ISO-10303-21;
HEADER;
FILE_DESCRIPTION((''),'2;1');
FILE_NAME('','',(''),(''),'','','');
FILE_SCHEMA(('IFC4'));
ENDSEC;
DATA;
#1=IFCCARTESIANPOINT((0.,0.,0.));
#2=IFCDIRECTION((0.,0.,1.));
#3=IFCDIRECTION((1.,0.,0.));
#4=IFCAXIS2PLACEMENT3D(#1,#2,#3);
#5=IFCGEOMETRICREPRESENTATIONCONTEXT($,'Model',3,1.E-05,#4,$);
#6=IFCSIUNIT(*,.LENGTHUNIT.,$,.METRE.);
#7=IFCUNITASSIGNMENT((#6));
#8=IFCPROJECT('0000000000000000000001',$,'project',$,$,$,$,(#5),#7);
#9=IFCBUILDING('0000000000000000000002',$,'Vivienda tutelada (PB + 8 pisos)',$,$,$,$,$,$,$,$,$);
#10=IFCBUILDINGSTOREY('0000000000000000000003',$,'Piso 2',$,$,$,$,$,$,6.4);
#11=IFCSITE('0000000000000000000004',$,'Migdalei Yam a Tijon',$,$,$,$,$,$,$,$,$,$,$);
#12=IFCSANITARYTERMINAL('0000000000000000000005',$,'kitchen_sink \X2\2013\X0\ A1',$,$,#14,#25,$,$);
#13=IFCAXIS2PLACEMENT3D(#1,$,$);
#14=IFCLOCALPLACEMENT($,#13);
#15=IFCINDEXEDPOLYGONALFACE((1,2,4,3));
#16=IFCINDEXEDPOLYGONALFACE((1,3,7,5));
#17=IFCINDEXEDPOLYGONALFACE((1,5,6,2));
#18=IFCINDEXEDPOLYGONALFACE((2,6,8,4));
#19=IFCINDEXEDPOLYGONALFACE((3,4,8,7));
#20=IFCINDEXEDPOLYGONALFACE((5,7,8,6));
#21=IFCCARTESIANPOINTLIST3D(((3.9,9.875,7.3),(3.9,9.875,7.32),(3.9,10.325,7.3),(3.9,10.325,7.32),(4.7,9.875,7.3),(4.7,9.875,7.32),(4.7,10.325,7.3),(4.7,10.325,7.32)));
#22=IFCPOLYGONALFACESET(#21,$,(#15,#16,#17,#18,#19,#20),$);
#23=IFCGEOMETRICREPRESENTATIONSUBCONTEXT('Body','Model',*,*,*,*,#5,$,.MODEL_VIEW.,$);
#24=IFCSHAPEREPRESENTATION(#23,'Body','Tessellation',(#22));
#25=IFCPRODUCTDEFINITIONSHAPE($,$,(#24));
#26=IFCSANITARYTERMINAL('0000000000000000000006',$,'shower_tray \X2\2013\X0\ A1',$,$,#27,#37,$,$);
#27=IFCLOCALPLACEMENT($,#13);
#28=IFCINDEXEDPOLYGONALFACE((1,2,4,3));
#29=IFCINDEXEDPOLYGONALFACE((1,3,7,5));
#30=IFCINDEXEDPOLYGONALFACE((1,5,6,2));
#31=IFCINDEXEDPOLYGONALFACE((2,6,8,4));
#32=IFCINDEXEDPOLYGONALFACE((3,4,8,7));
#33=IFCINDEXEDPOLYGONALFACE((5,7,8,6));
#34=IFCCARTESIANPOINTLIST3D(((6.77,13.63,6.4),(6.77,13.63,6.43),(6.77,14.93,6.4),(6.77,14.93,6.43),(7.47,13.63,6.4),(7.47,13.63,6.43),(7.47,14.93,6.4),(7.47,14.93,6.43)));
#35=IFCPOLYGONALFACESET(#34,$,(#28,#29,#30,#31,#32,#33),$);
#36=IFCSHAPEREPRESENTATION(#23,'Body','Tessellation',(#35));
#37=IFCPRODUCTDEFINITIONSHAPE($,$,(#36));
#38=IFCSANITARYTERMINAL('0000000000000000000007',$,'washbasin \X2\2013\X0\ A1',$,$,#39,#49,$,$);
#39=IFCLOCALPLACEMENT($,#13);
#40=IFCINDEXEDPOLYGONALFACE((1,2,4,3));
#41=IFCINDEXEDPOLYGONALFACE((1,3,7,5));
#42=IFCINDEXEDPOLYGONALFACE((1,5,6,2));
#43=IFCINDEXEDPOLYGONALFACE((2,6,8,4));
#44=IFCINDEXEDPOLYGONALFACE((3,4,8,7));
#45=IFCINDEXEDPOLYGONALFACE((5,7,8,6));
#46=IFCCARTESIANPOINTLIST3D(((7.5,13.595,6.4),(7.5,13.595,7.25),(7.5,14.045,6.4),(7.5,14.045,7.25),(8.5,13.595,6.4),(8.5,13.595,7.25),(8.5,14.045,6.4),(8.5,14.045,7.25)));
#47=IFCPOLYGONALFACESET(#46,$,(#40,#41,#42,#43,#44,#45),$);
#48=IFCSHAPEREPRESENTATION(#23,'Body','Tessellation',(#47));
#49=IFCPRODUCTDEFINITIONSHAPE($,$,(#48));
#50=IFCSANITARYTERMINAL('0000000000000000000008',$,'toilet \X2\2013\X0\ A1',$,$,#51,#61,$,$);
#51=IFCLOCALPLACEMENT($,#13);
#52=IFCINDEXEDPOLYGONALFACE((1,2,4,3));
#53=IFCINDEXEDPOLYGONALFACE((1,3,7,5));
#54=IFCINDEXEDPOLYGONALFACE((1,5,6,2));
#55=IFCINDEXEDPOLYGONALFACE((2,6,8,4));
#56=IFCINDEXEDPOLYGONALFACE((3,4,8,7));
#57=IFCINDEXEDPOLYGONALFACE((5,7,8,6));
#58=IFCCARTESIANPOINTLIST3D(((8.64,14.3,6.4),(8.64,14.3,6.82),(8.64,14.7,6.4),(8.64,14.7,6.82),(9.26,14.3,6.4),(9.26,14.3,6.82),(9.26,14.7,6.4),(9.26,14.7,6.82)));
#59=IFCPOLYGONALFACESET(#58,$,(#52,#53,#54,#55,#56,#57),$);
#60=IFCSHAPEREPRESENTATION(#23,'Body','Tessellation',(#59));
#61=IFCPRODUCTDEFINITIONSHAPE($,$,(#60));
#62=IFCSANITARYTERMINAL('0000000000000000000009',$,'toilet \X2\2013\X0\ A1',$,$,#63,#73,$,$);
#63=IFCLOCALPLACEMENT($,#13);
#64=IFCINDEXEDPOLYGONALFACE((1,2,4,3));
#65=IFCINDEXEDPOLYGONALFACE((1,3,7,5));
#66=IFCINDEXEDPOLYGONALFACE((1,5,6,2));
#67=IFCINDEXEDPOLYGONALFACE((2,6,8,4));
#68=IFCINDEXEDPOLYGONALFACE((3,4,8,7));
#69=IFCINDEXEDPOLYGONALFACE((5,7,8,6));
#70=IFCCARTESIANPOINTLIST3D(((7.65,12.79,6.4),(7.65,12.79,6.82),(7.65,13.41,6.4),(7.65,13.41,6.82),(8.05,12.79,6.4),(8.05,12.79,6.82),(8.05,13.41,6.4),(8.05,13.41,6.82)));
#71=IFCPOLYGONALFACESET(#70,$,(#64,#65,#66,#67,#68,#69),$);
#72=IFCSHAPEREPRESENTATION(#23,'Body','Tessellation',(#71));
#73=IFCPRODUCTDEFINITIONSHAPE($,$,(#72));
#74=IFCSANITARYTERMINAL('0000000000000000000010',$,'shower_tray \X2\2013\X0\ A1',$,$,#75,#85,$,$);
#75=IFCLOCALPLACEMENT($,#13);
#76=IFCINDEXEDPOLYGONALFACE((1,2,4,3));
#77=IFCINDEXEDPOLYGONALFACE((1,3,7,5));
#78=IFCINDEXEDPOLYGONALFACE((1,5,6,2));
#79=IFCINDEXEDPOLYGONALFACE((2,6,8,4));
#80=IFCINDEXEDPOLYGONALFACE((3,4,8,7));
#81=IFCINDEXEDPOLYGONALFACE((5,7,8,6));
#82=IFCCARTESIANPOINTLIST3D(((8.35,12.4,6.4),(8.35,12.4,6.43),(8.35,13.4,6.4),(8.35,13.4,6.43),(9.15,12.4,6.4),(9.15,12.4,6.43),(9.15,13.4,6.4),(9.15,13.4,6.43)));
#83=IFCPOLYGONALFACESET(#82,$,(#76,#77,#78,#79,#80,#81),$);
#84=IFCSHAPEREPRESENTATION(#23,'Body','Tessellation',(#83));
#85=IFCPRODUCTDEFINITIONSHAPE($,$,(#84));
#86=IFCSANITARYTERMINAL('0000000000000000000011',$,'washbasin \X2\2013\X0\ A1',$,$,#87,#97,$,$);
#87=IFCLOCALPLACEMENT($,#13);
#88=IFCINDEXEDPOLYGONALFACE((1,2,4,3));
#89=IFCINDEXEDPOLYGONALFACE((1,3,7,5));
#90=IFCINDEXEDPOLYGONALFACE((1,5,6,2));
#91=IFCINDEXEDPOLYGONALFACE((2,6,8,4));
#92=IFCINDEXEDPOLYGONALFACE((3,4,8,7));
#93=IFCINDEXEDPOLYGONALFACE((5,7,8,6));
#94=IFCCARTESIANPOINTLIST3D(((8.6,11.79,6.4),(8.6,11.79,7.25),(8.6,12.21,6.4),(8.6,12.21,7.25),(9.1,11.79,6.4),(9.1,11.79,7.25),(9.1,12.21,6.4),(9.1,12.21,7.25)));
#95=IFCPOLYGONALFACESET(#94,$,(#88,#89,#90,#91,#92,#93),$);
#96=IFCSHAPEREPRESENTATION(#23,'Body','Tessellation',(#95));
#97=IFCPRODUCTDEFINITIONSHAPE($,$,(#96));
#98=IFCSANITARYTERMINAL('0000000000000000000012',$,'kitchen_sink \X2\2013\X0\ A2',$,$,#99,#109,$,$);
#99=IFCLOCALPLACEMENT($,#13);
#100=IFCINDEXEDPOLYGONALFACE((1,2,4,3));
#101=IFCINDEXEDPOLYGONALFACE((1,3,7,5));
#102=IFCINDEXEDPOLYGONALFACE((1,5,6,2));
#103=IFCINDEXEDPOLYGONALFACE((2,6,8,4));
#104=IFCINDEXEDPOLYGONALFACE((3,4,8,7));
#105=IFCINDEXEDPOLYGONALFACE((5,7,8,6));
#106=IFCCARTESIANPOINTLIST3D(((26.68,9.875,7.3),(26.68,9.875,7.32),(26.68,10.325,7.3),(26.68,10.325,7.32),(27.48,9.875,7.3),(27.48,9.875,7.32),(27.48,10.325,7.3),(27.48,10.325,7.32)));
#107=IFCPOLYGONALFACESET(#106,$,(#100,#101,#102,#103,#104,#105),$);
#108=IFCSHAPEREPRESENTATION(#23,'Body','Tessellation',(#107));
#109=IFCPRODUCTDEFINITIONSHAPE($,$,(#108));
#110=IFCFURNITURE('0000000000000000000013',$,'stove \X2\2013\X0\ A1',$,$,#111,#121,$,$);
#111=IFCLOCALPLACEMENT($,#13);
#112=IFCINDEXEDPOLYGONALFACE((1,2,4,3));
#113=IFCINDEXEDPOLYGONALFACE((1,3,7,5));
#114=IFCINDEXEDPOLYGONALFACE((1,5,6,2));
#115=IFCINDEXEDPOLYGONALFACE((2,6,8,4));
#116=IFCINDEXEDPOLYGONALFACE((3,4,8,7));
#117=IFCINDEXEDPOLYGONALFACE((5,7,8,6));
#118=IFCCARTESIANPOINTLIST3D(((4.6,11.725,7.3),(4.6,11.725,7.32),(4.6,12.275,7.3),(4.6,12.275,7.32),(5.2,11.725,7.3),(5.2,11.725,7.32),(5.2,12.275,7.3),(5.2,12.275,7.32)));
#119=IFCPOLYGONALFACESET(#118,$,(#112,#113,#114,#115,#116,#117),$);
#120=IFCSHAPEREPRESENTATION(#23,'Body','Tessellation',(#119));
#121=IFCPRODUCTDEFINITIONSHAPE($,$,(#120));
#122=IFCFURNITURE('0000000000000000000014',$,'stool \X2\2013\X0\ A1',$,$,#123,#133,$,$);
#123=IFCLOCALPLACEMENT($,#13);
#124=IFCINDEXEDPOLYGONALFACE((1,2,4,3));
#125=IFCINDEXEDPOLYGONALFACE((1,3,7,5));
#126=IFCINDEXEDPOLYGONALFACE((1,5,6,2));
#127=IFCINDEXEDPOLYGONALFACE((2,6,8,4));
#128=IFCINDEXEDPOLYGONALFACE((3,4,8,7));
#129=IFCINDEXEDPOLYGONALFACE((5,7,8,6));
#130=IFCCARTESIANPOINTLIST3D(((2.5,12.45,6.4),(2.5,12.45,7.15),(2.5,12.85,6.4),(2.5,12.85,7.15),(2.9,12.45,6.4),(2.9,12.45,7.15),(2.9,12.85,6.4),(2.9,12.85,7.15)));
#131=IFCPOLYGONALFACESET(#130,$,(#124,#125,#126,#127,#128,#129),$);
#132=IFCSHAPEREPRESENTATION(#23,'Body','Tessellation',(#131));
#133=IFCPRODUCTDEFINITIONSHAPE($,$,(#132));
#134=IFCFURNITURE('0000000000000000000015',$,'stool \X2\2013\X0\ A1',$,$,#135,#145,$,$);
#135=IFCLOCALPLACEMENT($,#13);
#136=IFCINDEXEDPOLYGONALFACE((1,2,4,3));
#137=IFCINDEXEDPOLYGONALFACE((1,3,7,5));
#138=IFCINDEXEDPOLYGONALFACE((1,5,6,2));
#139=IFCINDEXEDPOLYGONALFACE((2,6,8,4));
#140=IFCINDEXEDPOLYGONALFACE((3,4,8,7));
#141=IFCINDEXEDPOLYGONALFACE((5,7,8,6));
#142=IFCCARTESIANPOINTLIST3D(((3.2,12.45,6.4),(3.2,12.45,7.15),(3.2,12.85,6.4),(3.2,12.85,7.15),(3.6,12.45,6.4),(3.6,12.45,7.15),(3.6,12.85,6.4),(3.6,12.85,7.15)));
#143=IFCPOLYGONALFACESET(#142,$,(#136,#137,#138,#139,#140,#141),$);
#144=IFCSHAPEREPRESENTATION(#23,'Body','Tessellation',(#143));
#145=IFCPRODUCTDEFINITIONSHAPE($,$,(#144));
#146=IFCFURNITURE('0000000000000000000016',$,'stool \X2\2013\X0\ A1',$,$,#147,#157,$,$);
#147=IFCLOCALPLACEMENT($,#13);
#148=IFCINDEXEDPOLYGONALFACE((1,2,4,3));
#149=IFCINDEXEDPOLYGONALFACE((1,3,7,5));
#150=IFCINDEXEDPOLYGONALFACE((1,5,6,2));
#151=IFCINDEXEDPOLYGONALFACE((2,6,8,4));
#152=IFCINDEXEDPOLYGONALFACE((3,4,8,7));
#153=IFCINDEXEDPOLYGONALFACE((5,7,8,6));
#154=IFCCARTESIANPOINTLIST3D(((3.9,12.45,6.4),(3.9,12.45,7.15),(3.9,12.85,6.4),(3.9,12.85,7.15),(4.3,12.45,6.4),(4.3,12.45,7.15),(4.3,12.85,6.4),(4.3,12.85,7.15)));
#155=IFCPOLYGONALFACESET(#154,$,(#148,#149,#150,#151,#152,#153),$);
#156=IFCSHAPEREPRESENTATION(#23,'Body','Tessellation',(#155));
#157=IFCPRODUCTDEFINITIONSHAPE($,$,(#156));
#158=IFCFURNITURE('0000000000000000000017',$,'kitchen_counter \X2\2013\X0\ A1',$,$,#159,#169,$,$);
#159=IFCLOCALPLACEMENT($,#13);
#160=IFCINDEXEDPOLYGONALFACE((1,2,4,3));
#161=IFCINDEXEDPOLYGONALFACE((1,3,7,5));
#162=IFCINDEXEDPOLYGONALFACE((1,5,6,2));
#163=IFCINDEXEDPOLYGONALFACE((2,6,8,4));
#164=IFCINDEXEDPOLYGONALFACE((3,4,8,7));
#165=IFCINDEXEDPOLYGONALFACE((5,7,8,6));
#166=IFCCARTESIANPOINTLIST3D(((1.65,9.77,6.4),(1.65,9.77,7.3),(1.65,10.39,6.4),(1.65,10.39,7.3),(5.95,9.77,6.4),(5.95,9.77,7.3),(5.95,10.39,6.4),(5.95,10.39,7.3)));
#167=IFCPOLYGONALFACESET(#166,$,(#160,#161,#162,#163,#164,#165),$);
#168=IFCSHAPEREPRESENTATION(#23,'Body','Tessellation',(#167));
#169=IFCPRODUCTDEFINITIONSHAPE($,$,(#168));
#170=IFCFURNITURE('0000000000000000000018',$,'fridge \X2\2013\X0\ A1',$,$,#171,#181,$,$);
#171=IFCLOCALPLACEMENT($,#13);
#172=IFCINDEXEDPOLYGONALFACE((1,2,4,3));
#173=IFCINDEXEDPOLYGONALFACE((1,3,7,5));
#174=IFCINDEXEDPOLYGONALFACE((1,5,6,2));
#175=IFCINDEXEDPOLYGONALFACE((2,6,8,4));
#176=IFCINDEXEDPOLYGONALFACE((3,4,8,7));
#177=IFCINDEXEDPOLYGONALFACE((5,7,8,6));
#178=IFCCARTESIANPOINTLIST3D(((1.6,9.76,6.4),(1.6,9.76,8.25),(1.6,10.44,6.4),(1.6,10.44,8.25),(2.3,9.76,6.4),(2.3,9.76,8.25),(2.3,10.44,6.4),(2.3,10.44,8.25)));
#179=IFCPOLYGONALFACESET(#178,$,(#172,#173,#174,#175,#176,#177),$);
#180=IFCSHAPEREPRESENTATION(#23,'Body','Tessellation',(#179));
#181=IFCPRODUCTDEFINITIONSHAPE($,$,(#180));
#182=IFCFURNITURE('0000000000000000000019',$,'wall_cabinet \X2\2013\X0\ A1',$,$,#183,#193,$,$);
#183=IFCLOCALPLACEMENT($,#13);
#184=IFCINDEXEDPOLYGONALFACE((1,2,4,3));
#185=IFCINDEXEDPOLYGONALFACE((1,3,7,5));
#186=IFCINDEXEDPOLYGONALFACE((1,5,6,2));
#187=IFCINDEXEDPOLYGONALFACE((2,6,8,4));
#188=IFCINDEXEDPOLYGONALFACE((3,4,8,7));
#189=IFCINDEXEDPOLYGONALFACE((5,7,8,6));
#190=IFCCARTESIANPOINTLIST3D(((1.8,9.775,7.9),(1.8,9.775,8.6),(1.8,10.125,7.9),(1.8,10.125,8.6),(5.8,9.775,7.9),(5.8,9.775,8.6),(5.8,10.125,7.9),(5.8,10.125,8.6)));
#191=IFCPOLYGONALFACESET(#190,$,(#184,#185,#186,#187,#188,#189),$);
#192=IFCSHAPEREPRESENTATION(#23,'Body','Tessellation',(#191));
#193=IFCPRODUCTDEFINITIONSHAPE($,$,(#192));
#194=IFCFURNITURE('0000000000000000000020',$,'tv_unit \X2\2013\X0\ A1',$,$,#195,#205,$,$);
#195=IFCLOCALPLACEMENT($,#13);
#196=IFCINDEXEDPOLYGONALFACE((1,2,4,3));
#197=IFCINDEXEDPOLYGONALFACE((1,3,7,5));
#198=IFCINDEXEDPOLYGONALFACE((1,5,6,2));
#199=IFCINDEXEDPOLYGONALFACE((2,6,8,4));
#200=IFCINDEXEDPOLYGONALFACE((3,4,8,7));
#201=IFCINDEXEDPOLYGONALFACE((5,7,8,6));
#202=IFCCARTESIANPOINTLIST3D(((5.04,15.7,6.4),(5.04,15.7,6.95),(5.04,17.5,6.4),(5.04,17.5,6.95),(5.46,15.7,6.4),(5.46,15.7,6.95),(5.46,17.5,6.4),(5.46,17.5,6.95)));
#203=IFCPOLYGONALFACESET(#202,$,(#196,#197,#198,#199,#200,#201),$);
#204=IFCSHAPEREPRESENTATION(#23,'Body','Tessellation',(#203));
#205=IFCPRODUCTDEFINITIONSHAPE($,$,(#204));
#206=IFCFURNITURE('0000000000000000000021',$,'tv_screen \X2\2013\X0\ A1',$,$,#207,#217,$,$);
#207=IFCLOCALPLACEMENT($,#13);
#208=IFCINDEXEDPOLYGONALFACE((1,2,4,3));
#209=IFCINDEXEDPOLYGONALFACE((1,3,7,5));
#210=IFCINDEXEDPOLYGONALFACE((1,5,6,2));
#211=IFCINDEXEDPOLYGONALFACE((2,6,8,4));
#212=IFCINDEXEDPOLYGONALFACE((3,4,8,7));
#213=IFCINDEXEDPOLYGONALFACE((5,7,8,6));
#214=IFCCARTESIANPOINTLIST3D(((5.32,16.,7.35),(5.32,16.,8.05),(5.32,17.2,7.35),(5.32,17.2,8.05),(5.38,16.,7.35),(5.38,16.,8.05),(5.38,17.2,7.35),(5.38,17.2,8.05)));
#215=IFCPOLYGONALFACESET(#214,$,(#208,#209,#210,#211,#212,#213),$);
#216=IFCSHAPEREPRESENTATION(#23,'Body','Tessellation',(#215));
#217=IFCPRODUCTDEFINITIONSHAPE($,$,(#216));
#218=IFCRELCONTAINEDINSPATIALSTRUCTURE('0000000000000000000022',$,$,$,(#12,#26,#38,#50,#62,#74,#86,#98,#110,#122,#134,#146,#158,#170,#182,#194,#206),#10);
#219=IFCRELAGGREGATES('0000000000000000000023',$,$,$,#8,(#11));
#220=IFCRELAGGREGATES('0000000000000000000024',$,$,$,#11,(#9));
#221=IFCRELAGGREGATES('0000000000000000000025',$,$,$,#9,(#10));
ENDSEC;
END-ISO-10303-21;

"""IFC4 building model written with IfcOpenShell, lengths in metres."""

from ifc_helpers import new_model, si_unit, frame, origin_with_axes, context, subcontext, project, spatial, line, indexed_curve, outline, extrude, element, save


model = new_model("IFC4")

# Units and contexts
model_context = context("Model", 3, precision=1e-05, world=origin_with_axes())
body_context = subcontext(model_context, "Body", "Model", "MODEL_VIEW")
ifc_project = project(units=[si_unit("LENGTHUNIT", "METRE")], contexts=[model_context])

# Site, building, storey
site = spatial("IfcSite", under=ifc_project, Name="Migdalei Yam a Tijon")
building = spatial("IfcBuilding", under=site, Name="Vivienda tutelada (PB + 8 pisos)")
storey = spatial("IfcBuildingStorey", under=building, Name="Piso 2", Elevation=6.4)

# Sanitary terminals
element("IfcSanitaryTerminal", 1, inside=storey, Name="kitchen_sink – A1", context=body_context, shape_type="SweptSolid", body=[
    extrude(outline(indexed_curve([(0.0, 0.0), (0.8, 0.0), (0.8, 0.45), (0.0, 0.45)], segments=[line(1, 2, 3, 4, 1)])), frame((3.9, 9.875, 7.3), z_axis=(0.0, 0.0, 1.0), x_axis=(1.0, 0.0, 0.0)), (0.0, 0.0, 1.0), 0.02),
])
element("IfcSanitaryTerminal", 2, inside=storey, Name="shower_tray – A1", context=body_context, shape_type="SweptSolid", body=[
    extrude(outline(indexed_curve([(0.0, 0.0), (0.7, 0.0), (0.7, 1.3), (0.0, 1.3)], segments=[line(1, 2, 3, 4, 1)])), frame((6.77, 13.63, 6.4), z_axis=(0.0, 0.0, 1.0), x_axis=(1.0, 0.0, 0.0)), (0.0, 0.0, 1.0), 0.03),
])
element("IfcSanitaryTerminal", 3, inside=storey, Name="washbasin – A1", context=body_context, shape_type="SweptSolid", body=[
    extrude(outline(indexed_curve([(0.0, 0.0), (1.0, 0.0), (1.0, 0.45), (0.0, 0.45)], segments=[line(1, 2, 3, 4, 1)])), frame((7.5, 13.595, 6.4), z_axis=(0.0, 0.0, 1.0), x_axis=(1.0, 0.0, 0.0)), (0.0, 0.0, 1.0), 0.85),
])
element("IfcSanitaryTerminal", 4, inside=storey, Name="toilet – A1", context=body_context, shape_type="SweptSolid", body=[
    extrude(outline(indexed_curve([(0.0, 0.0), (0.62, 0.0), (0.62, 0.4), (0.0, 0.4)], segments=[line(1, 2, 3, 4, 1)])), frame((8.64, 14.3, 6.4), z_axis=(0.0, 0.0, 1.0), x_axis=(1.0, 0.0, 0.0)), (0.0, 0.0, 1.0), 0.42),
])
element("IfcSanitaryTerminal", 5, inside=storey, Name="toilet – A1", context=body_context, shape_type="SweptSolid", body=[
    extrude(outline(indexed_curve([(0.0, 0.0), (0.4, 0.0), (0.4, 0.62), (0.0, 0.62)], segments=[line(1, 2, 3, 4, 1)])), frame((7.65, 12.79, 6.4), z_axis=(0.0, 0.0, 1.0), x_axis=(1.0, 0.0, 0.0)), (0.0, 0.0, 1.0), 0.42),
])
element("IfcSanitaryTerminal", 6, inside=storey, Name="shower_tray – A1", context=body_context, shape_type="SweptSolid", body=[
    extrude(outline(indexed_curve([(0.0, 0.0), (0.8, 0.0), (0.8, 1.0), (0.0, 1.0)], segments=[line(1, 2, 3, 4, 1)])), frame((8.35, 12.4, 6.4), z_axis=(0.0, 0.0, 1.0), x_axis=(1.0, 0.0, 0.0)), (0.0, 0.0, 1.0), 0.03),
])
element("IfcSanitaryTerminal", 7, inside=storey, Name="washbasin – A1", context=body_context, shape_type="SweptSolid", body=[
    extrude(outline(indexed_curve([(0.0, 0.0), (0.5, 0.0), (0.5, 0.42), (0.0, 0.42)], segments=[line(1, 2, 3, 4, 1)])), frame((8.6, 11.79, 6.4), z_axis=(0.0, 0.0, 1.0), x_axis=(1.0, 0.0, 0.0)), (0.0, 0.0, 1.0), 0.85),
])
element("IfcSanitaryTerminal", 8, inside=storey, Name="kitchen_sink – A2", context=body_context, shape_type="SweptSolid", body=[
    extrude(outline(indexed_curve([(0.0, 0.0), (0.8, 0.0), (0.8, 0.45), (0.0, 0.45)], segments=[line(1, 2, 3, 4, 1)])), frame((26.68, 9.875, 7.3), z_axis=(0.0, 0.0, 1.0), x_axis=(1.0, 0.0, 0.0)), (0.0, 0.0, 1.0), 0.02),
])

# Furniture
element("IfcFurniture", 9, inside=storey, Name="stove – A1", context=body_context, shape_type="SweptSolid", body=[
    extrude(outline(indexed_curve([(0.0, 0.0), (0.6, 0.0), (0.6, 0.55), (0.0, 0.55)], segments=[line(1, 2, 3, 4, 1)])), frame((4.6, 11.725, 7.3), z_axis=(0.0, 0.0, 1.0), x_axis=(1.0, 0.0, 0.0)), (0.0, 0.0, 1.0), 0.02),
])
element("IfcFurniture", 10, inside=storey, Name="stool – A1", context=body_context, shape_type="SweptSolid", body=[
    extrude(outline(indexed_curve([(0.0, 0.0), (0.4, 0.0), (0.4, 0.4), (0.0, 0.4)], segments=[line(1, 2, 3, 4, 1)])), frame((2.5, 12.45, 6.4), z_axis=(0.0, 0.0, 1.0), x_axis=(1.0, 0.0, 0.0)), (0.0, 0.0, 1.0), 0.75),
])
element("IfcFurniture", 11, inside=storey, Name="stool – A1", context=body_context, shape_type="SweptSolid", body=[
    extrude(outline(indexed_curve([(0.0, 0.0), (0.4, 0.0), (0.4, 0.4), (0.0, 0.4)], segments=[line(1, 2, 3, 4, 1)])), frame((3.2, 12.45, 6.4), z_axis=(0.0, 0.0, 1.0), x_axis=(1.0, 0.0, 0.0)), (0.0, 0.0, 1.0), 0.75),
])
element("IfcFurniture", 12, inside=storey, Name="stool – A1", context=body_context, shape_type="SweptSolid", body=[
    extrude(outline(indexed_curve([(0.0, 0.0), (0.4, 0.0), (0.4, 0.4), (0.0, 0.4)], segments=[line(1, 2, 3, 4, 1)])), frame((3.9, 12.45, 6.4), z_axis=(0.0, 0.0, 1.0), x_axis=(1.0, 0.0, 0.0)), (0.0, 0.0, 1.0), 0.75),
])
element("IfcFurniture", 13, inside=storey, Name="kitchen_counter – A1", context=body_context, shape_type="SweptSolid", body=[
    extrude(outline(indexed_curve([(0.0, 0.0), (4.3, 0.0), (4.3, 0.62), (0.0, 0.62)], segments=[line(1, 2, 3, 4, 1)])), frame((1.65, 9.77, 6.4), z_axis=(0.0, 0.0, 1.0), x_axis=(1.0, 0.0, 0.0)), (0.0, 0.0, 1.0), 0.9),
])
element("IfcFurniture", 14, inside=storey, Name="fridge – A1", context=body_context, shape_type="SweptSolid", body=[
    extrude(outline(indexed_curve([(0.0, 0.0), (0.7, 0.0), (0.7, 0.68), (0.0, 0.68)], segments=[line(1, 2, 3, 4, 1)])), frame((1.6, 9.76, 6.4), z_axis=(0.0, 0.0, 1.0), x_axis=(1.0, 0.0, 0.0)), (0.0, 0.0, 1.0), 1.85),
])
element("IfcFurniture", 15, inside=storey, Name="wall_cabinet – A1", context=body_context, shape_type="SweptSolid", body=[
    extrude(outline(indexed_curve([(0.0, 0.0), (4.0, 0.0), (4.0, 0.35), (0.0, 0.35)], segments=[line(1, 2, 3, 4, 1)])), frame((1.8, 9.775, 7.9), z_axis=(0.0, 0.0, 1.0), x_axis=(1.0, 0.0, 0.0)), (0.0, 0.0, 1.0), 0.7),
])
element("IfcFurniture", 16, inside=storey, Name="tv_unit – A1", context=body_context, shape_type="SweptSolid", body=[
    extrude(outline(indexed_curve([(0.0, 0.0), (0.42, 0.0), (0.42, 1.8), (0.0, 1.8)], segments=[line(1, 2, 3, 4, 1)])), frame((5.04, 15.7, 6.4), z_axis=(0.0, 0.0, 1.0), x_axis=(1.0, 0.0, 0.0)), (0.0, 0.0, 1.0), 0.55),
])
element("IfcFurniture", 17, inside=storey, Name="tv_screen – A1", context=body_context, shape_type="SweptSolid", body=[
    extrude(outline(indexed_curve([(0.0, 0.0), (0.06, 0.0), (0.06, 1.2), (0.0, 1.2)], segments=[line(1, 2, 3, 4, 1)])), frame((5.32, 16.0, 7.35), z_axis=(0.0, 0.0, 1.0), x_axis=(1.0, 0.0, 0.0)), (0.0, 0.0, 1.0), 0.7),
])

save(model, "model.ifc")
